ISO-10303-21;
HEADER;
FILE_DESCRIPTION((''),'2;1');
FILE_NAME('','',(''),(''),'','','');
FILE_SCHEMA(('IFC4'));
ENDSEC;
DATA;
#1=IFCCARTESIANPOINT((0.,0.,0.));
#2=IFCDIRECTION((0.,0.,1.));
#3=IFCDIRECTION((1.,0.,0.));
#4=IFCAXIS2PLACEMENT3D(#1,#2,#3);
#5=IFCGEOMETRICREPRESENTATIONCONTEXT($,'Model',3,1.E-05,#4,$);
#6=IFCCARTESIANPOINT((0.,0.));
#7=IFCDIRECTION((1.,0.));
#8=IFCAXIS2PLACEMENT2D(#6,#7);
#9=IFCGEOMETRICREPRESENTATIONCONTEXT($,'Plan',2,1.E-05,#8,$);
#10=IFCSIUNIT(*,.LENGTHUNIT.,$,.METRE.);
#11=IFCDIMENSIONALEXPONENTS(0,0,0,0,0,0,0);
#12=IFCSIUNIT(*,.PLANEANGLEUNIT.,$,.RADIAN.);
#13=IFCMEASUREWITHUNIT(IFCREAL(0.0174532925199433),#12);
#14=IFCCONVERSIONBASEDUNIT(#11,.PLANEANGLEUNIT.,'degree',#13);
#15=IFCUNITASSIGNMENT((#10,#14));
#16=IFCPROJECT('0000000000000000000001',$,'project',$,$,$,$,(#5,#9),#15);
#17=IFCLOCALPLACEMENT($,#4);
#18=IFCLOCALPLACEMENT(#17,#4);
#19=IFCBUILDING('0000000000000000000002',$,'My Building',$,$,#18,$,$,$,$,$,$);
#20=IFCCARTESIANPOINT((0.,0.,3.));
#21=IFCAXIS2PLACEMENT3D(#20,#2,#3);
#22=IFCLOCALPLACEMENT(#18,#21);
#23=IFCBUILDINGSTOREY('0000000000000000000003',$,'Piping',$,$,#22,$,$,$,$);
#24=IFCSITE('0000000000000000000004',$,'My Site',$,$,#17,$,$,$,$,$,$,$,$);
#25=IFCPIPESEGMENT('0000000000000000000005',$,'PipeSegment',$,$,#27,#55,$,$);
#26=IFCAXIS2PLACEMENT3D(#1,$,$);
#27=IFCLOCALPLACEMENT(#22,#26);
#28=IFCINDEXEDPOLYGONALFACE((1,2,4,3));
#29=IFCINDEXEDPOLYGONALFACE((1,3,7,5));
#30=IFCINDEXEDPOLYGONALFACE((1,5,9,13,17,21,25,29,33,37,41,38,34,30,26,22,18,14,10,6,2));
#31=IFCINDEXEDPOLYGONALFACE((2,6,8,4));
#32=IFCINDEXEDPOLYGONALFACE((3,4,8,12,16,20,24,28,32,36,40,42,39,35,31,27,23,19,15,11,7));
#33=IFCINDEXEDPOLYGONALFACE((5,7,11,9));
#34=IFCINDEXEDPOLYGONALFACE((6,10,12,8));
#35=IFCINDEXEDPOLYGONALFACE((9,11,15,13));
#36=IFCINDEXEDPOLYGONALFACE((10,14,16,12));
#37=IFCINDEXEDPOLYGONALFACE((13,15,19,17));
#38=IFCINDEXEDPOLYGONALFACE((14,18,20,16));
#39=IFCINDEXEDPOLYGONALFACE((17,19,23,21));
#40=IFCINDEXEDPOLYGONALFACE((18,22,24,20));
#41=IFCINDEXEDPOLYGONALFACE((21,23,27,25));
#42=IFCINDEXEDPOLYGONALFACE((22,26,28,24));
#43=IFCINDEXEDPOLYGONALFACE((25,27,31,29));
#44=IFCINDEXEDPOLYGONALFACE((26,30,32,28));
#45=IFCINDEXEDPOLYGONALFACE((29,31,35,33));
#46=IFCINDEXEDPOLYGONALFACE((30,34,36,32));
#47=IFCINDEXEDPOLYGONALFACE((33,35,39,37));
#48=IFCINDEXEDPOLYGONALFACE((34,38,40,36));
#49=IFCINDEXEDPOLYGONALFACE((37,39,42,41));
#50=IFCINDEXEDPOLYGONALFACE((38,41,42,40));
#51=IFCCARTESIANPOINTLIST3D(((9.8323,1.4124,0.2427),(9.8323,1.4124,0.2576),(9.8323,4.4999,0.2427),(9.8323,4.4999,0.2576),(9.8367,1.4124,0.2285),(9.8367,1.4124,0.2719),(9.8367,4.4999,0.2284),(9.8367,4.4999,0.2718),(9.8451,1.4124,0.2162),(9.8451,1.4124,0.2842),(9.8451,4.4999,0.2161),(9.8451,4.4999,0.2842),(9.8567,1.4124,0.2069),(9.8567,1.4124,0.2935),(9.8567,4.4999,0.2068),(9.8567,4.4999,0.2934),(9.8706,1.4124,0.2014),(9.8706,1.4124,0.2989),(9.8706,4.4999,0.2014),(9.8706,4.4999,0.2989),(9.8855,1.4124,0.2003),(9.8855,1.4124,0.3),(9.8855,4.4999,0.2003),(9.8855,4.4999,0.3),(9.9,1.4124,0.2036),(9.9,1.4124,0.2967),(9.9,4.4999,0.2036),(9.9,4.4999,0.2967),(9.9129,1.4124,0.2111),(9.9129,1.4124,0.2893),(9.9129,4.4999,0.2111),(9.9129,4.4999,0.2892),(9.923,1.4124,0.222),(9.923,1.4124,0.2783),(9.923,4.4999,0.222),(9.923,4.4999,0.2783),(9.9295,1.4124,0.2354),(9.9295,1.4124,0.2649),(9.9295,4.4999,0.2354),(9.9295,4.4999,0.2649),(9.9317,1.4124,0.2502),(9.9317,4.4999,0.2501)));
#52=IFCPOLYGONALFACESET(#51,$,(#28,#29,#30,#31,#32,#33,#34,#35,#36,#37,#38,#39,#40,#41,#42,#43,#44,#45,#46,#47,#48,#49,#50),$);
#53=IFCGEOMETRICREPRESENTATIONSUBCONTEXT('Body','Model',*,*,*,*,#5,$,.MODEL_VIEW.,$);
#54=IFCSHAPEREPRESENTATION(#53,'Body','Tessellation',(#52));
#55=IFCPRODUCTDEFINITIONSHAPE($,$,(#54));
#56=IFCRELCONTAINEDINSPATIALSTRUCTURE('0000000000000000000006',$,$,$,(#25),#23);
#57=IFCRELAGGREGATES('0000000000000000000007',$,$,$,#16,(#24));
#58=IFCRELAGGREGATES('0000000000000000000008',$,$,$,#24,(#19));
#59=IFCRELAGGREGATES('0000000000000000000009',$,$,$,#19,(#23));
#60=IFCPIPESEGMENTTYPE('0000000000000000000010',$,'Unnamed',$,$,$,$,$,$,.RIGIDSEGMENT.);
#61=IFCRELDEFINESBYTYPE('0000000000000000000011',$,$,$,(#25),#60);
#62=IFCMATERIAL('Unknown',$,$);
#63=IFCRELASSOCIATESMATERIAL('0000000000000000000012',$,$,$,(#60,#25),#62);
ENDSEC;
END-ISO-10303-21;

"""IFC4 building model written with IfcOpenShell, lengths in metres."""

from ifc_helpers import new_model, entity, si_unit, converted_unit, frame, origin_with_axes, origin_2d_with_axis, place, context, subcontext, project, spatial, circle, extrude, material, material_profile, profile_set, profile_usage, type_object, element, save


model = new_model("IFC4")

# Units and contexts
model_context = context("Model", 3, precision=1e-05, world=origin_with_axes())
plan_context = context("Plan", 2, precision=1e-05, world=origin_2d_with_axis())
body_context = subcontext(model_context, "Body", "Model", "MODEL_VIEW")
ifc_project = project(units=[si_unit("LENGTHUNIT", "METRE"), converted_unit("PLANEANGLEUNIT", "degree", entity("IfcReal", 0.0174532925199433), si_unit("PLANEANGLEUNIT", "RADIAN"), dimensions=[0, 0, 0, 0, 0, 0, 0])], contexts=[model_context, plan_context])

# Site, building, storey
site_placement = place(None, origin_with_axes())
site = spatial("IfcSite", under=ifc_project, at=site_placement, Name="My Site")
building_placement = place(site_placement, origin_with_axes())
building = spatial("IfcBuilding", under=site, at=building_placement, Name="My Building")
storey_placement = place(building_placement, frame((0.0, 0.0, 3.0), z_axis=(0.0, 0.0, 1.0), x_axis=(1.0, 0.0, 0.0)))
storey = spatial("IfcBuildingStorey", under=building, at=storey_placement, Name="Piping")

# Pipe segment
ifc_material = material(Name="Unknown")
ifc_material_profile_1 = material_profile(ifc_material, circle(Radius=0.05))
ifc_profile_set_1 = profile_set([ifc_material_profile_1])
pipe_segment_type = type_object("IfcPipeSegmentType", Name="Unnamed", PredefinedType="RIGIDSEGMENT", material=ifc_profile_set_1)
ifc_profile_usage_1 = profile_usage(ifc_profile_set_1, cardinal=5)
pipe_segment_1_placement = place(storey_placement, frame((9.8817, 4.4999, 0.2501), z_axis=(0.0, -1.0, 0.000008), x_axis=(1.0, 0.0, 0.0)))
element("IfcPipeSegment", 1, at=pipe_segment_1_placement, inside=storey, type_object=pipe_segment_type, material=ifc_profile_usage_1, Name="PipeSegment", context=body_context, shape_type="SweptSolid", body=[
    extrude(circle(Radius=0.05), origin_with_axes(), (0.0, 0.0, 1.0), 3.0875),
])

save(model, "model.ifc")
